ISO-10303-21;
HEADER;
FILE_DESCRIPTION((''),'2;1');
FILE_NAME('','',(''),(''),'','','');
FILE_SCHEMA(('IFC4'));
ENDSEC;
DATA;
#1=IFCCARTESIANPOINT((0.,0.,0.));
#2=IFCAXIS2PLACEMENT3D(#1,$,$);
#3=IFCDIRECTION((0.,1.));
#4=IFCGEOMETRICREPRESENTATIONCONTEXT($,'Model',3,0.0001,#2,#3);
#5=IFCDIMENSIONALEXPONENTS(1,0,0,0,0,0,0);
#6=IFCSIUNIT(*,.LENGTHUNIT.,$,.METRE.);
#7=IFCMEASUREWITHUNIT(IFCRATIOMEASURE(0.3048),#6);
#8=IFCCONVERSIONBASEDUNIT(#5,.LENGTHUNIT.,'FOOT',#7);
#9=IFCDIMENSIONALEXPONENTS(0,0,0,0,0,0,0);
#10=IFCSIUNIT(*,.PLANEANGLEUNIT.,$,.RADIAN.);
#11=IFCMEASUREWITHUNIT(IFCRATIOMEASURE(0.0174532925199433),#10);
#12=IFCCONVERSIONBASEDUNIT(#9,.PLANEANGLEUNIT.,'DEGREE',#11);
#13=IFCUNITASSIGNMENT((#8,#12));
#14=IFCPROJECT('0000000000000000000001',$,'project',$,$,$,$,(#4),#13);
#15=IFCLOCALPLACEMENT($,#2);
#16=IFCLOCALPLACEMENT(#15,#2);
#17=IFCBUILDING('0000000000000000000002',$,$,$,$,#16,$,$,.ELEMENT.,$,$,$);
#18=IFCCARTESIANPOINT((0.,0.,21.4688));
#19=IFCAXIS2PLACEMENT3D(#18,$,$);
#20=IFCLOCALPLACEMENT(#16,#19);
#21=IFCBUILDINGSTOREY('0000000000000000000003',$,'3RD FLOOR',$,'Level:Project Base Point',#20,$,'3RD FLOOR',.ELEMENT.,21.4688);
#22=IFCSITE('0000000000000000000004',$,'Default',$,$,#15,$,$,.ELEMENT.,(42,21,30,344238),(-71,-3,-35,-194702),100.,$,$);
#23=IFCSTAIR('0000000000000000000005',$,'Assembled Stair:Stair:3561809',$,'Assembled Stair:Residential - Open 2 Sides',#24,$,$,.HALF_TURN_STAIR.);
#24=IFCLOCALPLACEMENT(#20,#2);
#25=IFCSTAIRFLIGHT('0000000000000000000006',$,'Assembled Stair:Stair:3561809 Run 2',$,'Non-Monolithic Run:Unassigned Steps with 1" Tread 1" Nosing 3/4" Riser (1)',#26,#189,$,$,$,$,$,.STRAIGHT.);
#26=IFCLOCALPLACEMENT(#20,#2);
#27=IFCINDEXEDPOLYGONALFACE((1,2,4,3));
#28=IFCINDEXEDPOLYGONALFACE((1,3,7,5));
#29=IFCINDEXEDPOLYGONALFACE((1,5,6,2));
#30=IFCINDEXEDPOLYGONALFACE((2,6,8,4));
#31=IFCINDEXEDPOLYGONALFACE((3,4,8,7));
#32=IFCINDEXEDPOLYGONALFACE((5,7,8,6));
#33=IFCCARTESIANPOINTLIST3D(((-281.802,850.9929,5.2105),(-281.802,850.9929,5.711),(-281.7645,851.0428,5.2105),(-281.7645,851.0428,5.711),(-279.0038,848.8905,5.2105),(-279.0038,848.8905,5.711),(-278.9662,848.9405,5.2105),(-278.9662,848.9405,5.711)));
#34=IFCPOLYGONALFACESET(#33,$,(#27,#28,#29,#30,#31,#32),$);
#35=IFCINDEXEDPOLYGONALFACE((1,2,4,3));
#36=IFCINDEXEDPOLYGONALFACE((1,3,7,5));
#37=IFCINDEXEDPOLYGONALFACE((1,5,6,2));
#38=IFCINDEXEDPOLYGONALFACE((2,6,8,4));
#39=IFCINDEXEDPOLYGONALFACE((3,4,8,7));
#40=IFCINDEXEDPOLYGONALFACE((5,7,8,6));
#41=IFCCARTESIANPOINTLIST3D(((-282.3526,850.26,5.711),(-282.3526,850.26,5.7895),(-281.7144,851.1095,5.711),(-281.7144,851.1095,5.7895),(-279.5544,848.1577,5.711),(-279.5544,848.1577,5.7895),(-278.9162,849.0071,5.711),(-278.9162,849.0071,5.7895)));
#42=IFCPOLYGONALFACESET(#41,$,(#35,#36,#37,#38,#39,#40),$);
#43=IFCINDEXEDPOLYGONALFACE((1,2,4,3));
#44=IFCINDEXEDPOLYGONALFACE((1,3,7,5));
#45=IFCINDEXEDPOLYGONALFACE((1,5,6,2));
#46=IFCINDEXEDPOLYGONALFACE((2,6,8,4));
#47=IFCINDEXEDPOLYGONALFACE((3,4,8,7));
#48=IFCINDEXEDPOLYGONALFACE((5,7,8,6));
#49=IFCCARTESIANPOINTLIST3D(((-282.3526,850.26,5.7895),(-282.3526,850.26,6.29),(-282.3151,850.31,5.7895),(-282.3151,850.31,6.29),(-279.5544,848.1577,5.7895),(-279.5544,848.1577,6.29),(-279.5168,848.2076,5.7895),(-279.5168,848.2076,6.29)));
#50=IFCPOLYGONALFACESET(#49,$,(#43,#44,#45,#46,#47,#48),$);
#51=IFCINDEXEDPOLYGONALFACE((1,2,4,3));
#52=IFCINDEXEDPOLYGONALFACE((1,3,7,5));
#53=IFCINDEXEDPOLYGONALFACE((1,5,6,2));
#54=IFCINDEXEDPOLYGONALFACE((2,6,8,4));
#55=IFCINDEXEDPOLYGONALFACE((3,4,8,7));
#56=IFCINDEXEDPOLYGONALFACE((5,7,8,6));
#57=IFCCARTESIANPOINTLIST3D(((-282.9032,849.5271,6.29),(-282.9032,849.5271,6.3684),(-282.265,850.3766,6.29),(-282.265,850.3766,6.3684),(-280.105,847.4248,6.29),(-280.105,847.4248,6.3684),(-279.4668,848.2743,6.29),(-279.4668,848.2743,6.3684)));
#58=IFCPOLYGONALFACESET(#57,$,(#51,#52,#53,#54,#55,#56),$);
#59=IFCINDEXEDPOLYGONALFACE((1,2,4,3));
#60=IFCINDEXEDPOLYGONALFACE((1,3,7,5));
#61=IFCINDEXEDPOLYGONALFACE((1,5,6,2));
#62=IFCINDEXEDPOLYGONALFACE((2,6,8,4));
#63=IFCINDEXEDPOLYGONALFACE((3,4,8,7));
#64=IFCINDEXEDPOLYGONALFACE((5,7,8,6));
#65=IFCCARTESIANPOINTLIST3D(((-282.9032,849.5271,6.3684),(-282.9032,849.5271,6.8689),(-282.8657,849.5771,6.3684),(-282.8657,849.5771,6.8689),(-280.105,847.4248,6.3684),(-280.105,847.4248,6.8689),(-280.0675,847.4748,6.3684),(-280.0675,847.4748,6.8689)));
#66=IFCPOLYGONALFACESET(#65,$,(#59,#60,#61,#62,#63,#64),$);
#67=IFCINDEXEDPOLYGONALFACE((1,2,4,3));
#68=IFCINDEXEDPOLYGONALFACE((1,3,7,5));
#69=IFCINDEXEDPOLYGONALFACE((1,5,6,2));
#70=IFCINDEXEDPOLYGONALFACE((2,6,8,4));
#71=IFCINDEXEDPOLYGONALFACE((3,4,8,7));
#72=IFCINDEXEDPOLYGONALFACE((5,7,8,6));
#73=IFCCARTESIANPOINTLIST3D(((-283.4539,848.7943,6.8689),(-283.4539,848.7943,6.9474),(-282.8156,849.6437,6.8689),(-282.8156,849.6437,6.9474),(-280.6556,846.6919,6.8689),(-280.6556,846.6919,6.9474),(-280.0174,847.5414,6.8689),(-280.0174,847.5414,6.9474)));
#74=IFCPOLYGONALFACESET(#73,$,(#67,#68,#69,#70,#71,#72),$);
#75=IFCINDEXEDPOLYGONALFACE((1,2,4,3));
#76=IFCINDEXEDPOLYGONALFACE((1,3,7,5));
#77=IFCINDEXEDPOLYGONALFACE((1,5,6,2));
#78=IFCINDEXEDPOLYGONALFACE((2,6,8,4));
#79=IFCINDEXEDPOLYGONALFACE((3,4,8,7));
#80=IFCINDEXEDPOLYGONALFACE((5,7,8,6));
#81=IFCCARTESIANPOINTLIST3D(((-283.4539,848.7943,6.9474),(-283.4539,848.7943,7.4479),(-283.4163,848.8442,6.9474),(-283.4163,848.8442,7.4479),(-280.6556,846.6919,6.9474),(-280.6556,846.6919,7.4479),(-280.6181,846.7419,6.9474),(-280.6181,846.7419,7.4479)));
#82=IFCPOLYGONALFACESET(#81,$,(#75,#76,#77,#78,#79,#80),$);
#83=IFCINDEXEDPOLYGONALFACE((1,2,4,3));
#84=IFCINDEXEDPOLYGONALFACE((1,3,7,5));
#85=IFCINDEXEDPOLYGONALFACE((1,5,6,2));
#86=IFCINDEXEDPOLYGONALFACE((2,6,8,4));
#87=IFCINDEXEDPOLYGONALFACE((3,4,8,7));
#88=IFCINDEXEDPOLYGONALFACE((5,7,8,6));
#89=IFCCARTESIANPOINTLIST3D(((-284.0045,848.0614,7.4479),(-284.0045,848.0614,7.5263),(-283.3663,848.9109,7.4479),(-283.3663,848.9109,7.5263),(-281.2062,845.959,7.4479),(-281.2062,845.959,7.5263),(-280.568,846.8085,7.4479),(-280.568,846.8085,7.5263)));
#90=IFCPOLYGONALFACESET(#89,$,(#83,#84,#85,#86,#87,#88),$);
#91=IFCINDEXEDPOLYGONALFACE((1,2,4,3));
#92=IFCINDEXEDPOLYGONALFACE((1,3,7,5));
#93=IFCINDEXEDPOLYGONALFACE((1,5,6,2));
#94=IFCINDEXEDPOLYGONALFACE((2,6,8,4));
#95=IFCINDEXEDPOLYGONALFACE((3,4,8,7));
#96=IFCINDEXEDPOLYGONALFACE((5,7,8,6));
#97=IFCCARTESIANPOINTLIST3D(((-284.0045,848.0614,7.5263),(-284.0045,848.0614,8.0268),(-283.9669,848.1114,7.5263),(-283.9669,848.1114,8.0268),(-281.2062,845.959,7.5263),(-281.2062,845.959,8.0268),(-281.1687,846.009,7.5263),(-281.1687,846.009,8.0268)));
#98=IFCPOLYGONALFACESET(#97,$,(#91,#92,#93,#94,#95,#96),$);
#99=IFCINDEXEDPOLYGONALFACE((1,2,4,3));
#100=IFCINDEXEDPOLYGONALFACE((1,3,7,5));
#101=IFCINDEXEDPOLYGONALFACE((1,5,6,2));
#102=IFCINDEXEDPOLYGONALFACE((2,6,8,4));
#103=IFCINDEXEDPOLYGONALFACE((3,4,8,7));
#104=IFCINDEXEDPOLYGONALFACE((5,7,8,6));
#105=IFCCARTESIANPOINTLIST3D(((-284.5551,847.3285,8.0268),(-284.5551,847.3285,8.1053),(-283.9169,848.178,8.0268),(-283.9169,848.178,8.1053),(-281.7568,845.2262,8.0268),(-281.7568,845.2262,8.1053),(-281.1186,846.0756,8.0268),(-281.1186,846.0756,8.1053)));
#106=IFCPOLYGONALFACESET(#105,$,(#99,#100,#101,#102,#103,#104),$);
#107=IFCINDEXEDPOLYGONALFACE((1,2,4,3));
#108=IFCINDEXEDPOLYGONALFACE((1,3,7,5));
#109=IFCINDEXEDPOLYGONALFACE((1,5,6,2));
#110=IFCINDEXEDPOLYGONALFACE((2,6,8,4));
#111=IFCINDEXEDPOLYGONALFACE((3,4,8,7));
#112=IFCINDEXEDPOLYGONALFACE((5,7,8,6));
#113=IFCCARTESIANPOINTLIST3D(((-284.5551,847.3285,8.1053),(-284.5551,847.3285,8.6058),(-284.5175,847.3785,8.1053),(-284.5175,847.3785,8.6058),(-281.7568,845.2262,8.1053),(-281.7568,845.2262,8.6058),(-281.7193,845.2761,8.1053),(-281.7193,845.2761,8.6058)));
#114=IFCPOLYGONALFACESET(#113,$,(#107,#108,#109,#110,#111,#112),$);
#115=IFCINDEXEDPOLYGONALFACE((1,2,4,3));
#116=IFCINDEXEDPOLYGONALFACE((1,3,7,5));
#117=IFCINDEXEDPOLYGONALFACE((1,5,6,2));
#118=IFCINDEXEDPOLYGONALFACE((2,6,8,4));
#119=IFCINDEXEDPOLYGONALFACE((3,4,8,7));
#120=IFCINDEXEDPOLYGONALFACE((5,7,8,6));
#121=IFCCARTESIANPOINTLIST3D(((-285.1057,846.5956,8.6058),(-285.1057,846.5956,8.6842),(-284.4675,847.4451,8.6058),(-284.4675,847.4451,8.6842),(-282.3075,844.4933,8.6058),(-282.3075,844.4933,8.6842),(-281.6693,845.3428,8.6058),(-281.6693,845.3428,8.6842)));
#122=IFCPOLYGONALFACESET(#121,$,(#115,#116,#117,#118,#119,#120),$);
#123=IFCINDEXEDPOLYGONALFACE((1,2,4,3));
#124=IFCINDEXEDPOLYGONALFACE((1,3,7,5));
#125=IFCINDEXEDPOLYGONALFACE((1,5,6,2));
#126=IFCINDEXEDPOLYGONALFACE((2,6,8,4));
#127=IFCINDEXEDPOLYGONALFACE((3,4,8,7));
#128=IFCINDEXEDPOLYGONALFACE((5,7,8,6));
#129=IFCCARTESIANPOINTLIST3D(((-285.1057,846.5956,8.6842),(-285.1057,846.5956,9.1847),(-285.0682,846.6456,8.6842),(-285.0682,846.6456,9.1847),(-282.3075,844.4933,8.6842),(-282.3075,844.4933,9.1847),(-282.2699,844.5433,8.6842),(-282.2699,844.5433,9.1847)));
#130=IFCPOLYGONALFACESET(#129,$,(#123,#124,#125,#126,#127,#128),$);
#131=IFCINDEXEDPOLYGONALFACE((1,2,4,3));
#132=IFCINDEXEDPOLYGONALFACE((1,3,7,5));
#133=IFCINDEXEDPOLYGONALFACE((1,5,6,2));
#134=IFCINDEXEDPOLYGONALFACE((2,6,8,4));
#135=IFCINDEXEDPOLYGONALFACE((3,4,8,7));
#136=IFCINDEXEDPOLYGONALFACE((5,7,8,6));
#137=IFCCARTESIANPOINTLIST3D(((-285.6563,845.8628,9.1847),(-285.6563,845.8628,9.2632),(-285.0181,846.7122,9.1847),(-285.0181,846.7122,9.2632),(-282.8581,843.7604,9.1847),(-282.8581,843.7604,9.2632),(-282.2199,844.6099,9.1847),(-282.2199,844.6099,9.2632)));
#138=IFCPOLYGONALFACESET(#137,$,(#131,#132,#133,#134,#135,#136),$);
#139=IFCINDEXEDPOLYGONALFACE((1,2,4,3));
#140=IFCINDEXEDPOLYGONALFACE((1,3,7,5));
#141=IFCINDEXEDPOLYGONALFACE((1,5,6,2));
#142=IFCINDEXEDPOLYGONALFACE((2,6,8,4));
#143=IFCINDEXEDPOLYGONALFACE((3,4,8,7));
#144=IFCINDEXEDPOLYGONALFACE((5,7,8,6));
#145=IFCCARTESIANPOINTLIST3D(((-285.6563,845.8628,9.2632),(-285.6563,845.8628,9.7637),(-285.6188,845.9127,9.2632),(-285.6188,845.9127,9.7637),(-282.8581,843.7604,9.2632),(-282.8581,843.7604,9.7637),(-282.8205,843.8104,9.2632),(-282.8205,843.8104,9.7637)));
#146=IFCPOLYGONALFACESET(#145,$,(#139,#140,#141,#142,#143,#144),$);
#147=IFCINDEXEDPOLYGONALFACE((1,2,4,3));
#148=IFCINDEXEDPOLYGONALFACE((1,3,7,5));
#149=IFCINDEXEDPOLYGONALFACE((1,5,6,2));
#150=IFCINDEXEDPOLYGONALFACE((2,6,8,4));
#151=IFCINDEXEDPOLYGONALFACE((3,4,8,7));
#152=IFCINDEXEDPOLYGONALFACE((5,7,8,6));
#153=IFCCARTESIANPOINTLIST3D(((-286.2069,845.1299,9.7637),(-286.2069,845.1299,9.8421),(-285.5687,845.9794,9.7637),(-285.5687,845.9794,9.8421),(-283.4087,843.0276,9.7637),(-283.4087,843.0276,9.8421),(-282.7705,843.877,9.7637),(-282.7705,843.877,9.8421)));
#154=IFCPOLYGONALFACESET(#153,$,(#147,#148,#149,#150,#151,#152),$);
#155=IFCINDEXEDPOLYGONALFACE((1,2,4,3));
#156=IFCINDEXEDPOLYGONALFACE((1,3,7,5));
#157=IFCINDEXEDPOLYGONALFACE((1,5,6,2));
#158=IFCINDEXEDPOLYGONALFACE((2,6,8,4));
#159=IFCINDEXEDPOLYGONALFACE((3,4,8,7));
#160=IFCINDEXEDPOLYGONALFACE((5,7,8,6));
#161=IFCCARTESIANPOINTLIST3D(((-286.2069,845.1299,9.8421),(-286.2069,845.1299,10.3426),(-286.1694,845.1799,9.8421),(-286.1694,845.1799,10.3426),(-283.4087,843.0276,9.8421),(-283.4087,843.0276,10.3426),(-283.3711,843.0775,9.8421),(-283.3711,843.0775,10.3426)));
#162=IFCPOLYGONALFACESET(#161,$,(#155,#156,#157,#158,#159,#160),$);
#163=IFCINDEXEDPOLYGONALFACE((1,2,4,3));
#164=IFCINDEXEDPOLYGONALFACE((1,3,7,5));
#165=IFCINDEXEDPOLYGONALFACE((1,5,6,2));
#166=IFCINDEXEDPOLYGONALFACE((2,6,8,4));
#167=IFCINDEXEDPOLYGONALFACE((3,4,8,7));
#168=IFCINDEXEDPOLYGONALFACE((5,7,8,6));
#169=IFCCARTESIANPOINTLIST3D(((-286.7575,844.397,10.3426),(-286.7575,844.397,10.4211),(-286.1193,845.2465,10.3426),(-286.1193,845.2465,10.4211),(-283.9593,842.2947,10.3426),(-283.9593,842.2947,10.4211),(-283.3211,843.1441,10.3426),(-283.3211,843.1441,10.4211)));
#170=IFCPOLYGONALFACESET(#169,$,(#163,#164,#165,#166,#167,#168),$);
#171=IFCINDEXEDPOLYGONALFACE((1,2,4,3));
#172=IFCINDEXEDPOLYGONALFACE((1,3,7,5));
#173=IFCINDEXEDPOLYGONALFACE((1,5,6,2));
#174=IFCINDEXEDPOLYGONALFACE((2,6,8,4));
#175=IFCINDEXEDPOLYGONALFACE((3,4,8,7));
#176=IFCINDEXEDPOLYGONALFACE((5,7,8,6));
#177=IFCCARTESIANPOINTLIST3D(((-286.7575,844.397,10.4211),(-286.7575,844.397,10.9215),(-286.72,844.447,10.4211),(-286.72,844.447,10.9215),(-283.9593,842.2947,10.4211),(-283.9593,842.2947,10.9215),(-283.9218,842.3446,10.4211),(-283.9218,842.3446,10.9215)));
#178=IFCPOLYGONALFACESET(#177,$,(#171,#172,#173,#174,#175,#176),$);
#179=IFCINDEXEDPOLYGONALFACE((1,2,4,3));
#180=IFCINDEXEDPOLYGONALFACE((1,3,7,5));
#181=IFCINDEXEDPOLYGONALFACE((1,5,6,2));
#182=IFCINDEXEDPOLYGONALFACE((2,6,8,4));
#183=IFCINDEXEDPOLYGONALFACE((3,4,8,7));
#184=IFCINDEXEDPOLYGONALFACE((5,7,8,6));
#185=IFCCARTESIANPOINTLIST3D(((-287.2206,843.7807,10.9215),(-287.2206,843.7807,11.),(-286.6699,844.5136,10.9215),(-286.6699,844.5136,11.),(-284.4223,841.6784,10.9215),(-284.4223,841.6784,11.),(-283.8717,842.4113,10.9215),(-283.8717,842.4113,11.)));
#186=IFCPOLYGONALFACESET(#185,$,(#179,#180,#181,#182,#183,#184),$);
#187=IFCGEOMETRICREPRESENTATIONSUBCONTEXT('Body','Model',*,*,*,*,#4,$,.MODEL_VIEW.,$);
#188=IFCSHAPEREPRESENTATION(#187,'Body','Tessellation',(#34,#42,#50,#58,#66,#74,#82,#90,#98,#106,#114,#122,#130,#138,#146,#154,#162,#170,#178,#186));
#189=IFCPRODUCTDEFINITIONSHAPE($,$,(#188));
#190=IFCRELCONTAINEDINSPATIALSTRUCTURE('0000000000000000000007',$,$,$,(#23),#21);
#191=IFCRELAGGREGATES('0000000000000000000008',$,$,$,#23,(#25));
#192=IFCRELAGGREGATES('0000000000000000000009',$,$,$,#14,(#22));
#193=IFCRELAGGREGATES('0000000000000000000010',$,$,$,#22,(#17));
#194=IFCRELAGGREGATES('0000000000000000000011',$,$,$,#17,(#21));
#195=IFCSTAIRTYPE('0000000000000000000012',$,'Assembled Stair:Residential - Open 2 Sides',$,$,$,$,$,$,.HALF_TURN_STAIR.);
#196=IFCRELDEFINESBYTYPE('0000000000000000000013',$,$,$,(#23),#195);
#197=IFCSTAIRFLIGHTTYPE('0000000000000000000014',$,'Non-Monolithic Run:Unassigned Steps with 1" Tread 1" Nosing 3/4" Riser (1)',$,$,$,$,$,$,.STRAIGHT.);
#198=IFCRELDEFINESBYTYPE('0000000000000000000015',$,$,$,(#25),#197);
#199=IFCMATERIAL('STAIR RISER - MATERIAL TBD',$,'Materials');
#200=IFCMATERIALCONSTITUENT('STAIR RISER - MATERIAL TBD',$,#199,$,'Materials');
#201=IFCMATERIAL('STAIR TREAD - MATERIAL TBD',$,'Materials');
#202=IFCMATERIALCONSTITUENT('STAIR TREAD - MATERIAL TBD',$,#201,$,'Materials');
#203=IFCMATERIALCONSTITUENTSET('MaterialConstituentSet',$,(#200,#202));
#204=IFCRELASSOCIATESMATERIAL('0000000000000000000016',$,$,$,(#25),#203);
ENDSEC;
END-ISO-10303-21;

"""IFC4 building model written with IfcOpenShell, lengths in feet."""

from ifc_helpers import new_model, entity, si_unit, converted_unit, direction, frame, frame_2d, origin, origin_2d_with_axis, place, context, subcontext, project, spatial, rectangle, extrude, material, constituent, constituent_set, type_object, element, aggregate, save


model = new_model("IFC4")

# Units and contexts
model_context = context("Model", 3, precision=0.0001, world=origin(), true_north=direction((0.0, 1.0)))
body_context = subcontext(model_context, "Body", "Model", "MODEL_VIEW")
ifc_project = project(units=[converted_unit("LENGTHUNIT", "FOOT", entity("IfcRatioMeasure", 0.3048), si_unit("LENGTHUNIT", "METRE"), dimensions=[1, 0, 0, 0, 0, 0, 0]), converted_unit("PLANEANGLEUNIT", "DEGREE", entity("IfcRatioMeasure", 0.0174532925199433), si_unit("PLANEANGLEUNIT", "RADIAN"), dimensions=[0, 0, 0, 0, 0, 0, 0])], contexts=[model_context])

# Site, building, storey
site_placement = place(None, origin())
site = spatial("IfcSite", under=ifc_project, at=site_placement, Name="Default", CompositionType="ELEMENT", RefLatitude=(42, 21, 30, 344238), RefLongitude=(-71, -3, -35, -194702), RefElevation=100.0)
building_placement = place(site_placement, origin())
building = spatial("IfcBuilding", under=site, at=building_placement, CompositionType="ELEMENT")
storey_placement = place(building_placement, frame((0.0, 0.0, 21.4688)))
storey = spatial("IfcBuildingStorey", under=building, at=storey_placement, Name="3RD FLOOR", ObjectType="Level:Project Base Point", LongName="3RD FLOOR", CompositionType="ELEMENT", Elevation=21.4688)

# Stair
stair_type_1 = type_object("IfcStairType", Name="Assembled Stair:Residential - Open 2 Sides", PredefinedType="HALF_TURN_STAIR")
stair_1_placement = place(storey_placement, origin())
stair_1 = element("IfcStair", 1, at=stair_1_placement, inside=storey, type_object=stair_type_1, Name="Assembled Stair:Stair:3561809", ObjectType="Assembled Stair:Residential - Open 2 Sides", PredefinedType="HALF_TURN_STAIR")
ifc_material_1 = material(Name="STAIR TREAD - MATERIAL TBD", Category="Materials")

# Stair flight
ifc_material_2 = material(Name="STAIR RISER - MATERIAL TBD", Category="Materials")
ifc_constituent_1 = constituent(ifc_material_2, Name="STAIR RISER - MATERIAL TBD", Category="Materials")
ifc_constituent_2 = constituent(ifc_material_1, Name="STAIR TREAD - MATERIAL TBD", Category="Materials")
ifc_constituent_set_1 = constituent_set(constituents=[ifc_constituent_1, ifc_constituent_2], Name="MaterialConstituentSet")
stair_flight_type_1 = type_object("IfcStairFlightType", Name="Non-Monolithic Run:Unassigned Steps with 1\" Tread 1\" Nosing 3/4\" Riser (1)", PredefinedType="STRAIGHT")
stair_flight_1_placement = place(stair_1_placement, frame((-287.2206, 841.6784, 0.0)))
stair_flight_1 = element("IfcStairFlight", 2, at=stair_flight_1_placement, type_object=stair_flight_type_1, material=ifc_constituent_set_1, Name="Assembled Stair:Stair:3561809 Run 2", ObjectType="Non-Monolithic Run:Unassigned Steps with 1\" Tread 1\" Nosing 3/4\" Riser (1)", PredefinedType="STRAIGHT", context=body_context, shape_type="SweptSolid", body=[
    extrude(rectangle(XDim=3.5, YDim=0.0625, at=frame_2d((0.0, 0.0), x_axis=(1.0, 0.0))), frame((6.8364, 8.2883, 5.2105), z_axis=(0.0, 0.0, 1.0), x_axis=(0.799497, -0.60067, 0.0)), (0.0, 0.0, 1.0), 0.5005),
    extrude(rectangle(XDim=1.0625, YDim=3.5, at=frame_2d((0.0, 0.0), x_axis=(1.0, 0.0))), frame((6.5862, 7.9552, 5.711), z_axis=(0.0, 0.0, 1.0), x_axis=(0.60067, 0.799497, 0.0)), (0.0, 0.0, 1.0), 0.0785),
    extrude(rectangle(XDim=3.5, YDim=0.0625, at=origin_2d_with_axis()), frame((6.2858, 7.5554, 5.7895), z_axis=(0.0, 0.0, 1.0), x_axis=(0.799497, -0.60067, 0.0)), (0.0, 0.0, 1.0), 0.5005),
    extrude(rectangle(XDim=1.0625, YDim=3.5, at=origin_2d_with_axis()), frame((6.0355, 7.2223, 6.29), z_axis=(0.0, 0.0, 1.0), x_axis=(0.60067, 0.799497, 0.0)), (0.0, 0.0, 1.0), 0.0785),
    extrude(rectangle(XDim=3.5, YDim=0.0625, at=origin_2d_with_axis()), frame((5.7352, 6.8225, 6.3684), z_axis=(0.0, 0.0, 1.0), x_axis=(0.799497, -0.60067, 0.0)), (0.0, 0.0, 1.0), 0.5005),
    extrude(rectangle(XDim=1.0625, YDim=3.5, at=frame_2d((0.0, 0.0), x_axis=(1.0, 0.0))), frame((5.4849, 6.4894, 6.8689), z_axis=(0.0, 0.0, 1.0), x_axis=(0.60067, 0.799497, 0.0)), (0.0, 0.0, 1.0), 0.0785),
    extrude(rectangle(XDim=3.5, YDim=0.0625, at=origin_2d_with_axis()), frame((5.1846, 6.0897, 6.9474), z_axis=(0.0, 0.0, 1.0), x_axis=(0.799497, -0.60067, 0.0)), (0.0, 0.0, 1.0), 0.5005),
    extrude(rectangle(XDim=1.0625, YDim=3.5, at=frame_2d((0.0, 0.0), x_axis=(1.0, 0.0))), frame((4.9343, 5.7565, 7.4479), z_axis=(0.0, 0.0, 1.0), x_axis=(0.60067, 0.799497, 0.0)), (0.0, 0.0, 1.0), 0.0785),
    extrude(rectangle(XDim=3.5, YDim=0.0625, at=origin_2d_with_axis()), frame((4.634, 5.3568, 7.5263), z_axis=(0.0, 0.0, 1.0), x_axis=(0.799497, -0.60067, 0.0)), (0.0, 0.0, 1.0), 0.5005),
    extrude(rectangle(XDim=1.0625, YDim=3.5, at=origin_2d_with_axis()), frame((4.3837, 5.0237, 8.0268), z_axis=(0.0, 0.0, 1.0), x_axis=(0.60067, 0.799497, 0.0)), (0.0, 0.0, 1.0), 0.0785),
    extrude(rectangle(XDim=3.5, YDim=0.0625, at=origin_2d_with_axis()), frame((4.0834, 4.6239, 8.1053), z_axis=(0.0, 0.0, 1.0), x_axis=(0.799497, -0.60067, 0.0)), (0.0, 0.0, 1.0), 0.5005),
    extrude(rectangle(XDim=1.0625, YDim=3.5, at=frame_2d((0.0, 0.0), x_axis=(1.0, 0.0))), frame((3.8331, 4.2908, 8.6058), z_axis=(0.0, 0.0, 1.0), x_axis=(0.60067, 0.799497, 0.0)), (0.0, 0.0, 1.0), 0.0785),
    extrude(rectangle(XDim=3.5, YDim=0.0625, at=origin_2d_with_axis()), frame((3.5327, 3.8911, 8.6842), z_axis=(0.0, 0.0, 1.0), x_axis=(0.799497, -0.60067, 0.0)), (0.0, 0.0, 1.0), 0.5005),
    extrude(rectangle(XDim=1.0625, YDim=3.5, at=origin_2d_with_axis()), frame((3.2825, 3.5579, 9.1847), z_axis=(0.0, 0.0, 1.0), x_axis=(0.60067, 0.799497, 0.0)), (0.0, 0.0, 1.0), 0.0785),
    extrude(rectangle(XDim=3.5, YDim=0.0625, at=origin_2d_with_axis()), frame((2.9821, 3.1582, 9.2632), z_axis=(0.0, 0.0, 1.0), x_axis=(0.799497, -0.60067, 0.0)), (0.0, 0.0, 1.0), 0.5005),
    extrude(rectangle(XDim=1.0625, YDim=3.5, at=origin_2d_with_axis()), frame((2.7319, 2.8251, 9.7637), z_axis=(0.0, 0.0, 1.0), x_axis=(0.60067, 0.799497, 0.0)), (0.0, 0.0, 1.0), 0.0785),
    extrude(rectangle(XDim=3.5, YDim=0.0625, at=origin_2d_with_axis()), frame((2.4315, 2.4253, 9.8421), z_axis=(0.0, 0.0, 1.0), x_axis=(0.799497, -0.60067, 0.0)), (0.0, 0.0, 1.0), 0.5005),
    extrude(rectangle(XDim=1.0625, YDim=3.5, at=frame_2d((0.0, 0.0), x_axis=(1.0, 0.0))), frame((2.1812, 2.0922, 10.3426), z_axis=(0.0, 0.0, 1.0), x_axis=(0.60067, 0.799497, 0.0)), (0.0, 0.0, 1.0), 0.0785),
    extrude(rectangle(XDim=3.5, YDim=0.0625, at=frame_2d((0.0, 0.0), x_axis=(1.0, 0.0))), frame((1.8809, 1.6924, 10.4211), z_axis=(0.0, 0.0, 1.0), x_axis=(0.799497, -0.60067, 0.0)), (0.0, 0.0, 1.0), 0.5005),
    extrude(rectangle(XDim=0.9167, YDim=3.5, at=frame_2d((0.0, 0.0), x_axis=(1.0, 0.0))), frame((1.6744, 1.4176, 10.9215), z_axis=(0.0, 0.0, 1.0), x_axis=(0.60067, 0.799497, 0.0)), (0.0, 0.0, 1.0), 0.0785),
])
aggregate(stair_1, [stair_flight_1])

save(model, "model.ifc")
